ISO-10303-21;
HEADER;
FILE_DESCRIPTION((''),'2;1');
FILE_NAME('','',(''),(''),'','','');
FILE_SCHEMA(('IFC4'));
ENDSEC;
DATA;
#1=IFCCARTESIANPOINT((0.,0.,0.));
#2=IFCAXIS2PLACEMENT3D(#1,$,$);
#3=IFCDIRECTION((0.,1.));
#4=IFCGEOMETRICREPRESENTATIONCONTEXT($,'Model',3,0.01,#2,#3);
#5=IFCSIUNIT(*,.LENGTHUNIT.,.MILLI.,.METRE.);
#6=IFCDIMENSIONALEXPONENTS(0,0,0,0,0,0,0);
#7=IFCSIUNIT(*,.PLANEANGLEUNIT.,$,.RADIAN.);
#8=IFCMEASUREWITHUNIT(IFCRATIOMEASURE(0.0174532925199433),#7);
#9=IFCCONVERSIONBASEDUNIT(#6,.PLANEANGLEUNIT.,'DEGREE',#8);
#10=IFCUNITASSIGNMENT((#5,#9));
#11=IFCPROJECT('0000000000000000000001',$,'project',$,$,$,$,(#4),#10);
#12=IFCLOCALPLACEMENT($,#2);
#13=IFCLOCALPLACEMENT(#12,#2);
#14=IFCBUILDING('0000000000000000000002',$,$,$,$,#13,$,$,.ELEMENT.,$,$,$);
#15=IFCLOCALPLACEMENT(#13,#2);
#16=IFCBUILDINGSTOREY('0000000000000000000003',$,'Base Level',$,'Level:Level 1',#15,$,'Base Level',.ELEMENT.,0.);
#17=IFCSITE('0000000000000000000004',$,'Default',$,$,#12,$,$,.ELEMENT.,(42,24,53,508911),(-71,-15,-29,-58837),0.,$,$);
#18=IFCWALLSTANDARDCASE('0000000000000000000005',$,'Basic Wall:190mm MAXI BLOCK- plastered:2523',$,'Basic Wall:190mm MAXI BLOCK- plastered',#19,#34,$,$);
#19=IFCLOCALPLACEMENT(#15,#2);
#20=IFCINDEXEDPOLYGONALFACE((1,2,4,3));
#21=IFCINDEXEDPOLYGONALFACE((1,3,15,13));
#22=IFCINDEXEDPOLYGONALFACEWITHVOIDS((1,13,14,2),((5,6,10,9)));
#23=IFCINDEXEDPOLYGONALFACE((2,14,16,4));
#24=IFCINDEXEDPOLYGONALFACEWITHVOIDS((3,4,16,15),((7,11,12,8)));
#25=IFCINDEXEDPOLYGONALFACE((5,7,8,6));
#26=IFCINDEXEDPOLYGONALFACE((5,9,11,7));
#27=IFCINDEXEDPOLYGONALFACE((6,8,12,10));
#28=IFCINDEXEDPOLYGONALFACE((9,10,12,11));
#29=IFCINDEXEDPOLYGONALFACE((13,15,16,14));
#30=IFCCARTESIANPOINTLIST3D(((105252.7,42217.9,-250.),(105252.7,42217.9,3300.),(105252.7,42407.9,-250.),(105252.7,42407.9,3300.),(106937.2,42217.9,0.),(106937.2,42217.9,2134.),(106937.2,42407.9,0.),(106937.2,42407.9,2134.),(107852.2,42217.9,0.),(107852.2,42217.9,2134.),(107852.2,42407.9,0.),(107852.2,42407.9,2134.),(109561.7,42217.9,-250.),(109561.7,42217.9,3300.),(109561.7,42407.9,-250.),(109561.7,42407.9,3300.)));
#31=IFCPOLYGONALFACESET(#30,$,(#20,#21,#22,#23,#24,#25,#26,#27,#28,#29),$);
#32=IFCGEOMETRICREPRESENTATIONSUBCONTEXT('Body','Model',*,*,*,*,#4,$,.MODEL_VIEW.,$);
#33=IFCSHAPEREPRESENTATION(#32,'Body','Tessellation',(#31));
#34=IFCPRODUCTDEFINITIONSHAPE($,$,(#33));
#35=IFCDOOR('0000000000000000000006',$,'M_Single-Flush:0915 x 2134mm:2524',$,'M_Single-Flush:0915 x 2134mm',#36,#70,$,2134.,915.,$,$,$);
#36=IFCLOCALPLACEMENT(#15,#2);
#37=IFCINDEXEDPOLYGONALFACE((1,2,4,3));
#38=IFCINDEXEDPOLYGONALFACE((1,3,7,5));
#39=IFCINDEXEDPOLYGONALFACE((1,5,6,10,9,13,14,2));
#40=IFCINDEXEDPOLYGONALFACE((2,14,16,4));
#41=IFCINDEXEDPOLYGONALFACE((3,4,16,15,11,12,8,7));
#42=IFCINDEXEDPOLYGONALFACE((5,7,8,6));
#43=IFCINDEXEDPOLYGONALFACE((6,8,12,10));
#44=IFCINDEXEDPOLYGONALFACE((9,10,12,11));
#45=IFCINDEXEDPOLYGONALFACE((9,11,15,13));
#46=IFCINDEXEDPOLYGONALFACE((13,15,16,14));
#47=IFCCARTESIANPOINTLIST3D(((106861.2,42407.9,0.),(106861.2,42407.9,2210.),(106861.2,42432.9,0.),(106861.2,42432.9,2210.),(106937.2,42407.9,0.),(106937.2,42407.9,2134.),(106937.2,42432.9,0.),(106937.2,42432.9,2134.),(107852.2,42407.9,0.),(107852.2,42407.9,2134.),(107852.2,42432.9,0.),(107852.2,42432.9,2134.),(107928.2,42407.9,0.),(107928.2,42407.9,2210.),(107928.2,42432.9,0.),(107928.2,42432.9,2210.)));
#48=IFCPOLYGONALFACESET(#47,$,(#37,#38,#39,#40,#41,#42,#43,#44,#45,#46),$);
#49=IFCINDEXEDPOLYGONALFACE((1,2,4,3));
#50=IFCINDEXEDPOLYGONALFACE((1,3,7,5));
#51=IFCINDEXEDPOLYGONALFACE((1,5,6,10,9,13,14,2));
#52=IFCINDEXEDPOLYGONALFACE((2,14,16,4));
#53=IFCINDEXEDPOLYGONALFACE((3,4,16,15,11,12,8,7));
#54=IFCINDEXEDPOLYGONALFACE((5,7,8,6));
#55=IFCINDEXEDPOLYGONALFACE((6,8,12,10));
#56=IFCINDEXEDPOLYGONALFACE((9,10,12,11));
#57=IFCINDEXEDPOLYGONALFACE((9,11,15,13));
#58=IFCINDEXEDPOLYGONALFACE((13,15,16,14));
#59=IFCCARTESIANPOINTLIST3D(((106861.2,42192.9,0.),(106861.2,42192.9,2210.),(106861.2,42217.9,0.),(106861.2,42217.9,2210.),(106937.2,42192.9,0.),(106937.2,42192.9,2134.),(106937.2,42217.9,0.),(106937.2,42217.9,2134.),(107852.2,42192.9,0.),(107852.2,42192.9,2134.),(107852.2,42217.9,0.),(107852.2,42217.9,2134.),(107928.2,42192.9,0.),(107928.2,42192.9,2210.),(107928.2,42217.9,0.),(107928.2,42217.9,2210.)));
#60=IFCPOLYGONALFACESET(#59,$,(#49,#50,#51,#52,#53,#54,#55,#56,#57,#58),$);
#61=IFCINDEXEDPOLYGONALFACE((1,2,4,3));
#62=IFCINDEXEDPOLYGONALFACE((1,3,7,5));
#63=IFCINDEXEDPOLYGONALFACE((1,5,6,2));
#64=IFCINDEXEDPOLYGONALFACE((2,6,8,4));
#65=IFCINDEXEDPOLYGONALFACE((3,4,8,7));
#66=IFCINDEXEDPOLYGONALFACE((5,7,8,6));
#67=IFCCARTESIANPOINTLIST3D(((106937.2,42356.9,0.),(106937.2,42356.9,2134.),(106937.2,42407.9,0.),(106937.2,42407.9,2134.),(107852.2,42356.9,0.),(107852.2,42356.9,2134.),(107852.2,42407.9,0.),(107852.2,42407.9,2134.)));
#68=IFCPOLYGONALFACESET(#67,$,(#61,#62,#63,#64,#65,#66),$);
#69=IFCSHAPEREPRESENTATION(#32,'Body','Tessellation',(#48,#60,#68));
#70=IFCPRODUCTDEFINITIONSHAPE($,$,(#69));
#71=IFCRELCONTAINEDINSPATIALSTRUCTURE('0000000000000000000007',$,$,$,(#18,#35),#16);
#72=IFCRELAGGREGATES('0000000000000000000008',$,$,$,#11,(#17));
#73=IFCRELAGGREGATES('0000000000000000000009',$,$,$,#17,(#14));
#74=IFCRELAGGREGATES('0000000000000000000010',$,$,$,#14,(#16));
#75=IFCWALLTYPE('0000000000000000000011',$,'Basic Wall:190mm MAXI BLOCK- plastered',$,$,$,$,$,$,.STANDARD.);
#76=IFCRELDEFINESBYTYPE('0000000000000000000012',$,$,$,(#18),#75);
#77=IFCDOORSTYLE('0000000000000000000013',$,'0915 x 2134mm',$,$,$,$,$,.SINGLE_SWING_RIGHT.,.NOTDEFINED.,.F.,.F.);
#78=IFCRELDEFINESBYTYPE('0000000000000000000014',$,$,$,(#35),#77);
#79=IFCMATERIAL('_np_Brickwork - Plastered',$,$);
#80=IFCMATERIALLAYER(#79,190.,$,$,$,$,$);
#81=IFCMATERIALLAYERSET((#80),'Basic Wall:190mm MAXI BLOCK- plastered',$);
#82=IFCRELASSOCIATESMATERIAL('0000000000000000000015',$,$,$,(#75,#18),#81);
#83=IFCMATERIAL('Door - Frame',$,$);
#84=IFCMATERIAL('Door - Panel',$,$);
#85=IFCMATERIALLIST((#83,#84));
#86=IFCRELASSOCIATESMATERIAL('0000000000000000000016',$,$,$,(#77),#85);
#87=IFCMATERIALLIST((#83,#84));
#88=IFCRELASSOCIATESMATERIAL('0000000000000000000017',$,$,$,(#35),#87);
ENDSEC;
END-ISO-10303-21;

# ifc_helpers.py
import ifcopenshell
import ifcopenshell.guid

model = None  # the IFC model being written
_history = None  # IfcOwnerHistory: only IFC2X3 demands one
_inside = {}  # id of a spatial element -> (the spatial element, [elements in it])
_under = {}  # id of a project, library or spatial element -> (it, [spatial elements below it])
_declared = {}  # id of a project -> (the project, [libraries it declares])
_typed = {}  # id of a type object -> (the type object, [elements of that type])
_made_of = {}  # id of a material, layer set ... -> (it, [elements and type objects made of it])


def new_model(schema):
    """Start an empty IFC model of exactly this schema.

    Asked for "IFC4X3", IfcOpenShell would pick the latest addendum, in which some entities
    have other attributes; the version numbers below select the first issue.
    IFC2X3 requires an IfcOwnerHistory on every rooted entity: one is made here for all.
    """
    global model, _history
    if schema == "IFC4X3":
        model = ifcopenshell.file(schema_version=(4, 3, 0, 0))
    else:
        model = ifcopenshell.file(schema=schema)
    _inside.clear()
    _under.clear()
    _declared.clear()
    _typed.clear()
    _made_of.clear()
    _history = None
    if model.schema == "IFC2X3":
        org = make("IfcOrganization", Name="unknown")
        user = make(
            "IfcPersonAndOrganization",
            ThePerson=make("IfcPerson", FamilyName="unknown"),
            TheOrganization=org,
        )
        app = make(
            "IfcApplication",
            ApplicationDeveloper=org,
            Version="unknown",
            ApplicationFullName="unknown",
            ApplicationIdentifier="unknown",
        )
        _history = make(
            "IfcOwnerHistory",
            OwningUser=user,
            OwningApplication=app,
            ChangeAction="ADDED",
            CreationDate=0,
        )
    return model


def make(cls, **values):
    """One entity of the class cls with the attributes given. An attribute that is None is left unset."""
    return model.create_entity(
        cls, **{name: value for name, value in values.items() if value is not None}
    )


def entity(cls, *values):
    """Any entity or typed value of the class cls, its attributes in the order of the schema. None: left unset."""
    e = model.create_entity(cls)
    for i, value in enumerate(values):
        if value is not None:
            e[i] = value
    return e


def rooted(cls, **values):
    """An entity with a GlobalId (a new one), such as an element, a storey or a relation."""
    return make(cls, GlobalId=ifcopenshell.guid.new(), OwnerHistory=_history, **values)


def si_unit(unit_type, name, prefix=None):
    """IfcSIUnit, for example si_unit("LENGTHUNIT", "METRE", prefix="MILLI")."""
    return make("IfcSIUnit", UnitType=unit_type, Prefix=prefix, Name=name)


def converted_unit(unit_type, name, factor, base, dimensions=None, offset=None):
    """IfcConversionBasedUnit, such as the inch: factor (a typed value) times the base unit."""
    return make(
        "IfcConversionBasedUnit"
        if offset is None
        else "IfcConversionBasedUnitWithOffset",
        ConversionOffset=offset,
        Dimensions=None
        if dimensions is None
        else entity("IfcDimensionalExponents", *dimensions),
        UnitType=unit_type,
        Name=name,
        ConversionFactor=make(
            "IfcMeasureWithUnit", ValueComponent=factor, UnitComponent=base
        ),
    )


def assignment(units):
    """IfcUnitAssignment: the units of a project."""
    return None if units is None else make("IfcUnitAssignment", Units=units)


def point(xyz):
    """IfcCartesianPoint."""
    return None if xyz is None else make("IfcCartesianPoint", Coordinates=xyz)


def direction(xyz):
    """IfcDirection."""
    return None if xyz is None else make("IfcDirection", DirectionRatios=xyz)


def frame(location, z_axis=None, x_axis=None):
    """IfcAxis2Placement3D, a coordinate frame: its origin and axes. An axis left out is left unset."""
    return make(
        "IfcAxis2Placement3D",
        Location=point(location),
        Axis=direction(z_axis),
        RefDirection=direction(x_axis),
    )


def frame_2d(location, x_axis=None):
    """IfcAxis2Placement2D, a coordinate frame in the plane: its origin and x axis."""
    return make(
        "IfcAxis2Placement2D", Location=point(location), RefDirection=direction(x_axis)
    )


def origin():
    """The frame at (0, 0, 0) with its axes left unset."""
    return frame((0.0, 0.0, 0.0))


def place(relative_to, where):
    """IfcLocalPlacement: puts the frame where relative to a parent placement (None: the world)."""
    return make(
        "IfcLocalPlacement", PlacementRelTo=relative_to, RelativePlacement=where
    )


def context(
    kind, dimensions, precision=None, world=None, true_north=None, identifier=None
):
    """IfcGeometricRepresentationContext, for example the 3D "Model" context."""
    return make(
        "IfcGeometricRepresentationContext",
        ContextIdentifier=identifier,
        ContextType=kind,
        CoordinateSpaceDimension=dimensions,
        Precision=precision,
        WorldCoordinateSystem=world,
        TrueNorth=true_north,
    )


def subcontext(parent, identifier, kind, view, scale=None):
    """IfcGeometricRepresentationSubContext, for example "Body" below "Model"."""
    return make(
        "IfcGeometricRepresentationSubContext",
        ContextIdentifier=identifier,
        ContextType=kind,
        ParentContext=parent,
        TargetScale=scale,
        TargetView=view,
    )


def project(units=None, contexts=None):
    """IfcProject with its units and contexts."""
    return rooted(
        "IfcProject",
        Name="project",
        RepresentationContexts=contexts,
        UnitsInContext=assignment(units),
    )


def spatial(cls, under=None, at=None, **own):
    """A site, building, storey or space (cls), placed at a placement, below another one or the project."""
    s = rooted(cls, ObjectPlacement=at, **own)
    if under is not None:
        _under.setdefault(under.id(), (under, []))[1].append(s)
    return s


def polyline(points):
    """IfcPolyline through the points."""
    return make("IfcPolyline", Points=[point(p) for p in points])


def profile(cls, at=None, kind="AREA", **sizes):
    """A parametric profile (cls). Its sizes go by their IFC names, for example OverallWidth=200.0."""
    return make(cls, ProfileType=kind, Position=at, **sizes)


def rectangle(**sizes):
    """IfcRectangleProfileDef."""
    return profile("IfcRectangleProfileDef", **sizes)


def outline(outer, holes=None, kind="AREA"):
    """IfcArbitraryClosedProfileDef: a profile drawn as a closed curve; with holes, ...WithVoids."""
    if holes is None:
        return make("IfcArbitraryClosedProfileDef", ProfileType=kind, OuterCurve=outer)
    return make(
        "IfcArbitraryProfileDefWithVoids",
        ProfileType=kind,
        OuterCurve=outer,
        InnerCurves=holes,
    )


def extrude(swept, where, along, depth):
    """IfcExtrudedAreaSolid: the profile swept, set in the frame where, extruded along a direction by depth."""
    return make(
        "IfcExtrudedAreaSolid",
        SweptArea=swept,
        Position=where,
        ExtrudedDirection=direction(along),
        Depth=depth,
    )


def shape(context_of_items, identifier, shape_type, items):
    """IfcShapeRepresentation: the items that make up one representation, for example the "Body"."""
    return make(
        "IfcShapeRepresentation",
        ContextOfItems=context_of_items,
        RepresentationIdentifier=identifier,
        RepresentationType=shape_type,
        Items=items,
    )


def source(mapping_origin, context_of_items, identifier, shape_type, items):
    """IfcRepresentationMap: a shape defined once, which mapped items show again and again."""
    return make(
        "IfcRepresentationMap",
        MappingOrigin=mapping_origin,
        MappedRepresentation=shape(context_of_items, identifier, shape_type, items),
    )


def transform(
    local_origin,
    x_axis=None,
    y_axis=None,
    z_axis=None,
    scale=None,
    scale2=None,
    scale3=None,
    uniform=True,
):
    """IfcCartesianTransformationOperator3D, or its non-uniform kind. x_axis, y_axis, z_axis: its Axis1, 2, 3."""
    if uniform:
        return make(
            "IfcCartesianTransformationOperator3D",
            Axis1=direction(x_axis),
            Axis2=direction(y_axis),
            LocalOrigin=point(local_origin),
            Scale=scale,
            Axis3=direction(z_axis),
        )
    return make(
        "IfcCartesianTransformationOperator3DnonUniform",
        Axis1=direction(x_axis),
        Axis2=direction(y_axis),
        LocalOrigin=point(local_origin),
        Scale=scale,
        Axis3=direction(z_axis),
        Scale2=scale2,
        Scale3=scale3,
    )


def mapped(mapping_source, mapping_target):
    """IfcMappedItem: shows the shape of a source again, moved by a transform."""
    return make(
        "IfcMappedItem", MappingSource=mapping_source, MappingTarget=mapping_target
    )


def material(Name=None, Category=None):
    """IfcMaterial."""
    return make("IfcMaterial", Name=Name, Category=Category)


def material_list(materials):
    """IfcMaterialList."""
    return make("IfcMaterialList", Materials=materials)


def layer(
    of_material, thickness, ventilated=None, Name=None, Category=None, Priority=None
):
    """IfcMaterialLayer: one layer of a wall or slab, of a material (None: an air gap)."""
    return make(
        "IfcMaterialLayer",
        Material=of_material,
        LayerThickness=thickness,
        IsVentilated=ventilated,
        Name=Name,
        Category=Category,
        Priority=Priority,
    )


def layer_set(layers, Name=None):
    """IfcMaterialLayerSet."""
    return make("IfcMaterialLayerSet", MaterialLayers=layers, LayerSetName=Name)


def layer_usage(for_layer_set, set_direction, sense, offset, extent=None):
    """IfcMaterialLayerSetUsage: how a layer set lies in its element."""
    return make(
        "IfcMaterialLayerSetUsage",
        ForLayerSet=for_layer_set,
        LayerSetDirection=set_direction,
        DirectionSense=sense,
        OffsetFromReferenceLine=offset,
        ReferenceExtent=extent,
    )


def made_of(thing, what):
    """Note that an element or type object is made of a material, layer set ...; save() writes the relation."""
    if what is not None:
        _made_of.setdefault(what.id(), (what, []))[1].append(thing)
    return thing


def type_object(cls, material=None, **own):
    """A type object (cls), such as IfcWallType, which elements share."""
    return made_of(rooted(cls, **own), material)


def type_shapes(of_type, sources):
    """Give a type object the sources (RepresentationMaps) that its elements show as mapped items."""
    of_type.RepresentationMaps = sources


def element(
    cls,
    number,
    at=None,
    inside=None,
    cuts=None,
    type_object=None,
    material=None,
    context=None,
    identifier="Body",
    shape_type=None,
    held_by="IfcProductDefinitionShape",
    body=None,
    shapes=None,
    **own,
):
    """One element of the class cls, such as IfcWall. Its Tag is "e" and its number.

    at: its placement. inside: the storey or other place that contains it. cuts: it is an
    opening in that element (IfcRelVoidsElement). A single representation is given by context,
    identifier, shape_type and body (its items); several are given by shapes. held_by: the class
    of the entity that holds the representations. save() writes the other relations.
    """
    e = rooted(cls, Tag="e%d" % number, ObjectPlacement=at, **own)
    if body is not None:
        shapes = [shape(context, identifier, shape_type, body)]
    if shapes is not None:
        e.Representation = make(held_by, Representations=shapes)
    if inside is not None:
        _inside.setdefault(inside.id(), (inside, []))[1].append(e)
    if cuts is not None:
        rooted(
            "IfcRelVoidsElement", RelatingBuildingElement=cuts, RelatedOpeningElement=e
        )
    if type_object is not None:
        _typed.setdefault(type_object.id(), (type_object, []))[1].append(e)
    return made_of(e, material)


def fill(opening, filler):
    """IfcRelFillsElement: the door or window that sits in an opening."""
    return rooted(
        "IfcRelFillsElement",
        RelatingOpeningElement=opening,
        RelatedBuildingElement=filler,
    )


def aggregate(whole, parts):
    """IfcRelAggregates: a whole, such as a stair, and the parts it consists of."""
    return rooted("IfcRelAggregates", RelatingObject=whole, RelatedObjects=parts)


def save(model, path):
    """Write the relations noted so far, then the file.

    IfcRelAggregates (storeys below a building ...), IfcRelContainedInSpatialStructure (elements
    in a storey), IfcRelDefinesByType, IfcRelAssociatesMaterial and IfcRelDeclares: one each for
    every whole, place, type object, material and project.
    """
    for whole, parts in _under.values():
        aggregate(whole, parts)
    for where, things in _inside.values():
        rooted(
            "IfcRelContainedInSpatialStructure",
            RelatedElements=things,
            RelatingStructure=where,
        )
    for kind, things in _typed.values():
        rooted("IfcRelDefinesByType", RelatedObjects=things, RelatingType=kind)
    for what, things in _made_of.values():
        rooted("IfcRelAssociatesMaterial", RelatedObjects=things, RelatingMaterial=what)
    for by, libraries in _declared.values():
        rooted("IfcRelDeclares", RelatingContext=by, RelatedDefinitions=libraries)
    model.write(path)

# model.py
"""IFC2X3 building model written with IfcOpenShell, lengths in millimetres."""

from ifc_helpers import new_model, entity, si_unit, converted_unit, direction, frame, frame_2d, origin, place, context, subcontext, project, spatial, polyline, rectangle, outline, extrude, source, transform, mapped, material, material_list, layer, layer_set, layer_usage, type_object, type_shapes, element, fill, save


model = new_model("IFC2X3")

# Units and contexts
model_context = context("Model", 3, precision=0.01, world=origin(), true_north=direction((0.0, 1.0)))
body_context = subcontext(model_context, "Body", "Model", "MODEL_VIEW")
ifc_project = project(units=[si_unit("LENGTHUNIT", "METRE", prefix="MILLI"), converted_unit("PLANEANGLEUNIT", "DEGREE", entity("IfcRatioMeasure", 0.0174532925199433), si_unit("PLANEANGLEUNIT", "RADIAN"), dimensions=[0, 0, 0, 0, 0, 0, 0])], contexts=[model_context])

# Site, building, storey
site_placement = place(None, origin())
site = spatial("IfcSite", under=ifc_project, at=site_placement, Name="Default", CompositionType="ELEMENT", RefLatitude=(42, 24, 53, 508911), RefLongitude=(-71, -15, -29, -58837), RefElevation=0.0)
building_placement = place(site_placement, origin())
building = spatial("IfcBuilding", under=site, at=building_placement, CompositionType="ELEMENT")
storey_placement = place(building_placement, origin())
storey = spatial("IfcBuildingStorey", under=building, at=storey_placement, Name="Base Level", ObjectType="Level:Level 1", LongName="Base Level", CompositionType="ELEMENT", Elevation=0.0)

# Shared definitions
ifc_material_1 = material(Name="_np_Brickwork - Plastered")
ifc_layer_1 = layer(ifc_material_1, 190.0)
ifc_layer_set_1 = layer_set([ifc_layer_1], Name="Basic Wall:190mm MAXI BLOCK- plastered")
wall_type = type_object("IfcWallType", Name="Basic Wall:190mm MAXI BLOCK- plastered", PredefinedType="STANDARD", material=ifc_layer_set_1)

# Wall, opening, door
ifc_layer_usage_1 = layer_usage(ifc_layer_set_1, "AXIS2", "NEGATIVE", 95.0)
wall_1_placement = place(building_placement, frame((105252.7, 42312.9, -250.0)))
wall_1 = element("IfcWallStandardCase", 1, at=wall_1_placement, inside=storey, type_object=wall_type, material=ifc_layer_usage_1, Name="Basic Wall:190mm MAXI BLOCK- plastered:2523", ObjectType="Basic Wall:190mm MAXI BLOCK- plastered", context=body_context, shape_type="SweptSolid", body=[
    extrude(rectangle(XDim=4309.0, YDim=190.0, at=frame_2d((2154.5, 0.0), x_axis=(-1.0, 0.0))), origin(), (0.0, 0.0, 1.0), 3550.0),
])
opening_1_placement = place(wall_1_placement, frame((1684.5, -95.0, 250.0)))
opening_1 = element("IfcOpeningElement", 2, at=opening_1_placement, cuts=wall_1, ObjectType="Opening", context=body_context, shape_type="SweptSolid", body=[
    extrude(rectangle(XDim=915.0, YDim=2134.0, at=frame_2d((1067.0, 457.5), x_axis=(0.0, 1.0))), frame((0.0, 0.0, 0.0), z_axis=(0.0, 1.0, 0.0), x_axis=(0.0, 0.0, 1.0)), (0.0, 0.0, 1.0), 190.0),
])
ifc_material_2 = material(Name="Door - Frame")
ifc_material_3 = material(Name="Door - Panel")
ifc_material_list_1 = material_list([ifc_material_2, ifc_material_3])
ifc_material_list_2 = material_list([ifc_material_2, ifc_material_3])
door_style = type_object("IfcDoorStyle", Name="0915 x 2134mm", ConstructionType="NOTDEFINED", OperationType="SINGLE_SWING_RIGHT", ParameterTakesPrecedence=False, Sizeable=False, material=ifc_material_list_2)
shared_shape_1 = source(origin(), body_context, "Body", "SweptSolid", [
    extrude(outline(polyline([(-533.5, -1124.0), (533.5, -1124.0), (533.5, 1086.0), (457.5, 1086.0), (457.5, -1048.0), (-457.5, -1048.0), (-457.5, 1086.0), (-533.5, 1086.0), (-533.5, -1124.0)])), frame((457.5, 190.0, 1086.0), z_axis=(0.0, 1.0, 0.0), x_axis=(1.0, 0.0, 0.0)), (0.0, 0.0, 1.0), 25.0),
    extrude(outline(polyline([(-1124.0, -533.5), (1086.0, -533.5), (1086.0, -457.5), (-1048.0, -457.5), (-1048.0, 457.5), (1086.0, 457.5), (1086.0, 533.5), (-1124.0, 533.5), (-1124.0, -533.5)])), frame((457.5, -25.0, 1086.0), z_axis=(0.0, 1.0, 0.0), x_axis=(0.0, 0.0, -1.0)), (0.0, 0.0, 1.0), 25.0),
    extrude(rectangle(XDim=51.0, YDim=915.0, at=frame_2d((0.0, 0.0), x_axis=(1.0, 0.0))), frame((457.5, 164.5, 0.0), z_axis=(0.0, 0.0, 1.0), x_axis=(0.0, 1.0, 0.0)), (0.0, 0.0, 1.0), 2134.0),
])
type_shapes(door_style, [shared_shape_1])
door_placement = place(opening_1_placement, origin())
door = element("IfcDoor", 3, at=door_placement, inside=storey, type_object=door_style, material=ifc_material_list_1, Name="M_Single-Flush:0915 x 2134mm:2524", ObjectType="M_Single-Flush:0915 x 2134mm", OverallHeight=2134.0, OverallWidth=915.0, context=body_context, shape_type="MappedRepresentation", body=[
    mapped(shared_shape_1, transform((0.0, 0.0, 0.0), scale=1.0)),
])
fill(opening_1, door)

save(model, "model.ifc")
